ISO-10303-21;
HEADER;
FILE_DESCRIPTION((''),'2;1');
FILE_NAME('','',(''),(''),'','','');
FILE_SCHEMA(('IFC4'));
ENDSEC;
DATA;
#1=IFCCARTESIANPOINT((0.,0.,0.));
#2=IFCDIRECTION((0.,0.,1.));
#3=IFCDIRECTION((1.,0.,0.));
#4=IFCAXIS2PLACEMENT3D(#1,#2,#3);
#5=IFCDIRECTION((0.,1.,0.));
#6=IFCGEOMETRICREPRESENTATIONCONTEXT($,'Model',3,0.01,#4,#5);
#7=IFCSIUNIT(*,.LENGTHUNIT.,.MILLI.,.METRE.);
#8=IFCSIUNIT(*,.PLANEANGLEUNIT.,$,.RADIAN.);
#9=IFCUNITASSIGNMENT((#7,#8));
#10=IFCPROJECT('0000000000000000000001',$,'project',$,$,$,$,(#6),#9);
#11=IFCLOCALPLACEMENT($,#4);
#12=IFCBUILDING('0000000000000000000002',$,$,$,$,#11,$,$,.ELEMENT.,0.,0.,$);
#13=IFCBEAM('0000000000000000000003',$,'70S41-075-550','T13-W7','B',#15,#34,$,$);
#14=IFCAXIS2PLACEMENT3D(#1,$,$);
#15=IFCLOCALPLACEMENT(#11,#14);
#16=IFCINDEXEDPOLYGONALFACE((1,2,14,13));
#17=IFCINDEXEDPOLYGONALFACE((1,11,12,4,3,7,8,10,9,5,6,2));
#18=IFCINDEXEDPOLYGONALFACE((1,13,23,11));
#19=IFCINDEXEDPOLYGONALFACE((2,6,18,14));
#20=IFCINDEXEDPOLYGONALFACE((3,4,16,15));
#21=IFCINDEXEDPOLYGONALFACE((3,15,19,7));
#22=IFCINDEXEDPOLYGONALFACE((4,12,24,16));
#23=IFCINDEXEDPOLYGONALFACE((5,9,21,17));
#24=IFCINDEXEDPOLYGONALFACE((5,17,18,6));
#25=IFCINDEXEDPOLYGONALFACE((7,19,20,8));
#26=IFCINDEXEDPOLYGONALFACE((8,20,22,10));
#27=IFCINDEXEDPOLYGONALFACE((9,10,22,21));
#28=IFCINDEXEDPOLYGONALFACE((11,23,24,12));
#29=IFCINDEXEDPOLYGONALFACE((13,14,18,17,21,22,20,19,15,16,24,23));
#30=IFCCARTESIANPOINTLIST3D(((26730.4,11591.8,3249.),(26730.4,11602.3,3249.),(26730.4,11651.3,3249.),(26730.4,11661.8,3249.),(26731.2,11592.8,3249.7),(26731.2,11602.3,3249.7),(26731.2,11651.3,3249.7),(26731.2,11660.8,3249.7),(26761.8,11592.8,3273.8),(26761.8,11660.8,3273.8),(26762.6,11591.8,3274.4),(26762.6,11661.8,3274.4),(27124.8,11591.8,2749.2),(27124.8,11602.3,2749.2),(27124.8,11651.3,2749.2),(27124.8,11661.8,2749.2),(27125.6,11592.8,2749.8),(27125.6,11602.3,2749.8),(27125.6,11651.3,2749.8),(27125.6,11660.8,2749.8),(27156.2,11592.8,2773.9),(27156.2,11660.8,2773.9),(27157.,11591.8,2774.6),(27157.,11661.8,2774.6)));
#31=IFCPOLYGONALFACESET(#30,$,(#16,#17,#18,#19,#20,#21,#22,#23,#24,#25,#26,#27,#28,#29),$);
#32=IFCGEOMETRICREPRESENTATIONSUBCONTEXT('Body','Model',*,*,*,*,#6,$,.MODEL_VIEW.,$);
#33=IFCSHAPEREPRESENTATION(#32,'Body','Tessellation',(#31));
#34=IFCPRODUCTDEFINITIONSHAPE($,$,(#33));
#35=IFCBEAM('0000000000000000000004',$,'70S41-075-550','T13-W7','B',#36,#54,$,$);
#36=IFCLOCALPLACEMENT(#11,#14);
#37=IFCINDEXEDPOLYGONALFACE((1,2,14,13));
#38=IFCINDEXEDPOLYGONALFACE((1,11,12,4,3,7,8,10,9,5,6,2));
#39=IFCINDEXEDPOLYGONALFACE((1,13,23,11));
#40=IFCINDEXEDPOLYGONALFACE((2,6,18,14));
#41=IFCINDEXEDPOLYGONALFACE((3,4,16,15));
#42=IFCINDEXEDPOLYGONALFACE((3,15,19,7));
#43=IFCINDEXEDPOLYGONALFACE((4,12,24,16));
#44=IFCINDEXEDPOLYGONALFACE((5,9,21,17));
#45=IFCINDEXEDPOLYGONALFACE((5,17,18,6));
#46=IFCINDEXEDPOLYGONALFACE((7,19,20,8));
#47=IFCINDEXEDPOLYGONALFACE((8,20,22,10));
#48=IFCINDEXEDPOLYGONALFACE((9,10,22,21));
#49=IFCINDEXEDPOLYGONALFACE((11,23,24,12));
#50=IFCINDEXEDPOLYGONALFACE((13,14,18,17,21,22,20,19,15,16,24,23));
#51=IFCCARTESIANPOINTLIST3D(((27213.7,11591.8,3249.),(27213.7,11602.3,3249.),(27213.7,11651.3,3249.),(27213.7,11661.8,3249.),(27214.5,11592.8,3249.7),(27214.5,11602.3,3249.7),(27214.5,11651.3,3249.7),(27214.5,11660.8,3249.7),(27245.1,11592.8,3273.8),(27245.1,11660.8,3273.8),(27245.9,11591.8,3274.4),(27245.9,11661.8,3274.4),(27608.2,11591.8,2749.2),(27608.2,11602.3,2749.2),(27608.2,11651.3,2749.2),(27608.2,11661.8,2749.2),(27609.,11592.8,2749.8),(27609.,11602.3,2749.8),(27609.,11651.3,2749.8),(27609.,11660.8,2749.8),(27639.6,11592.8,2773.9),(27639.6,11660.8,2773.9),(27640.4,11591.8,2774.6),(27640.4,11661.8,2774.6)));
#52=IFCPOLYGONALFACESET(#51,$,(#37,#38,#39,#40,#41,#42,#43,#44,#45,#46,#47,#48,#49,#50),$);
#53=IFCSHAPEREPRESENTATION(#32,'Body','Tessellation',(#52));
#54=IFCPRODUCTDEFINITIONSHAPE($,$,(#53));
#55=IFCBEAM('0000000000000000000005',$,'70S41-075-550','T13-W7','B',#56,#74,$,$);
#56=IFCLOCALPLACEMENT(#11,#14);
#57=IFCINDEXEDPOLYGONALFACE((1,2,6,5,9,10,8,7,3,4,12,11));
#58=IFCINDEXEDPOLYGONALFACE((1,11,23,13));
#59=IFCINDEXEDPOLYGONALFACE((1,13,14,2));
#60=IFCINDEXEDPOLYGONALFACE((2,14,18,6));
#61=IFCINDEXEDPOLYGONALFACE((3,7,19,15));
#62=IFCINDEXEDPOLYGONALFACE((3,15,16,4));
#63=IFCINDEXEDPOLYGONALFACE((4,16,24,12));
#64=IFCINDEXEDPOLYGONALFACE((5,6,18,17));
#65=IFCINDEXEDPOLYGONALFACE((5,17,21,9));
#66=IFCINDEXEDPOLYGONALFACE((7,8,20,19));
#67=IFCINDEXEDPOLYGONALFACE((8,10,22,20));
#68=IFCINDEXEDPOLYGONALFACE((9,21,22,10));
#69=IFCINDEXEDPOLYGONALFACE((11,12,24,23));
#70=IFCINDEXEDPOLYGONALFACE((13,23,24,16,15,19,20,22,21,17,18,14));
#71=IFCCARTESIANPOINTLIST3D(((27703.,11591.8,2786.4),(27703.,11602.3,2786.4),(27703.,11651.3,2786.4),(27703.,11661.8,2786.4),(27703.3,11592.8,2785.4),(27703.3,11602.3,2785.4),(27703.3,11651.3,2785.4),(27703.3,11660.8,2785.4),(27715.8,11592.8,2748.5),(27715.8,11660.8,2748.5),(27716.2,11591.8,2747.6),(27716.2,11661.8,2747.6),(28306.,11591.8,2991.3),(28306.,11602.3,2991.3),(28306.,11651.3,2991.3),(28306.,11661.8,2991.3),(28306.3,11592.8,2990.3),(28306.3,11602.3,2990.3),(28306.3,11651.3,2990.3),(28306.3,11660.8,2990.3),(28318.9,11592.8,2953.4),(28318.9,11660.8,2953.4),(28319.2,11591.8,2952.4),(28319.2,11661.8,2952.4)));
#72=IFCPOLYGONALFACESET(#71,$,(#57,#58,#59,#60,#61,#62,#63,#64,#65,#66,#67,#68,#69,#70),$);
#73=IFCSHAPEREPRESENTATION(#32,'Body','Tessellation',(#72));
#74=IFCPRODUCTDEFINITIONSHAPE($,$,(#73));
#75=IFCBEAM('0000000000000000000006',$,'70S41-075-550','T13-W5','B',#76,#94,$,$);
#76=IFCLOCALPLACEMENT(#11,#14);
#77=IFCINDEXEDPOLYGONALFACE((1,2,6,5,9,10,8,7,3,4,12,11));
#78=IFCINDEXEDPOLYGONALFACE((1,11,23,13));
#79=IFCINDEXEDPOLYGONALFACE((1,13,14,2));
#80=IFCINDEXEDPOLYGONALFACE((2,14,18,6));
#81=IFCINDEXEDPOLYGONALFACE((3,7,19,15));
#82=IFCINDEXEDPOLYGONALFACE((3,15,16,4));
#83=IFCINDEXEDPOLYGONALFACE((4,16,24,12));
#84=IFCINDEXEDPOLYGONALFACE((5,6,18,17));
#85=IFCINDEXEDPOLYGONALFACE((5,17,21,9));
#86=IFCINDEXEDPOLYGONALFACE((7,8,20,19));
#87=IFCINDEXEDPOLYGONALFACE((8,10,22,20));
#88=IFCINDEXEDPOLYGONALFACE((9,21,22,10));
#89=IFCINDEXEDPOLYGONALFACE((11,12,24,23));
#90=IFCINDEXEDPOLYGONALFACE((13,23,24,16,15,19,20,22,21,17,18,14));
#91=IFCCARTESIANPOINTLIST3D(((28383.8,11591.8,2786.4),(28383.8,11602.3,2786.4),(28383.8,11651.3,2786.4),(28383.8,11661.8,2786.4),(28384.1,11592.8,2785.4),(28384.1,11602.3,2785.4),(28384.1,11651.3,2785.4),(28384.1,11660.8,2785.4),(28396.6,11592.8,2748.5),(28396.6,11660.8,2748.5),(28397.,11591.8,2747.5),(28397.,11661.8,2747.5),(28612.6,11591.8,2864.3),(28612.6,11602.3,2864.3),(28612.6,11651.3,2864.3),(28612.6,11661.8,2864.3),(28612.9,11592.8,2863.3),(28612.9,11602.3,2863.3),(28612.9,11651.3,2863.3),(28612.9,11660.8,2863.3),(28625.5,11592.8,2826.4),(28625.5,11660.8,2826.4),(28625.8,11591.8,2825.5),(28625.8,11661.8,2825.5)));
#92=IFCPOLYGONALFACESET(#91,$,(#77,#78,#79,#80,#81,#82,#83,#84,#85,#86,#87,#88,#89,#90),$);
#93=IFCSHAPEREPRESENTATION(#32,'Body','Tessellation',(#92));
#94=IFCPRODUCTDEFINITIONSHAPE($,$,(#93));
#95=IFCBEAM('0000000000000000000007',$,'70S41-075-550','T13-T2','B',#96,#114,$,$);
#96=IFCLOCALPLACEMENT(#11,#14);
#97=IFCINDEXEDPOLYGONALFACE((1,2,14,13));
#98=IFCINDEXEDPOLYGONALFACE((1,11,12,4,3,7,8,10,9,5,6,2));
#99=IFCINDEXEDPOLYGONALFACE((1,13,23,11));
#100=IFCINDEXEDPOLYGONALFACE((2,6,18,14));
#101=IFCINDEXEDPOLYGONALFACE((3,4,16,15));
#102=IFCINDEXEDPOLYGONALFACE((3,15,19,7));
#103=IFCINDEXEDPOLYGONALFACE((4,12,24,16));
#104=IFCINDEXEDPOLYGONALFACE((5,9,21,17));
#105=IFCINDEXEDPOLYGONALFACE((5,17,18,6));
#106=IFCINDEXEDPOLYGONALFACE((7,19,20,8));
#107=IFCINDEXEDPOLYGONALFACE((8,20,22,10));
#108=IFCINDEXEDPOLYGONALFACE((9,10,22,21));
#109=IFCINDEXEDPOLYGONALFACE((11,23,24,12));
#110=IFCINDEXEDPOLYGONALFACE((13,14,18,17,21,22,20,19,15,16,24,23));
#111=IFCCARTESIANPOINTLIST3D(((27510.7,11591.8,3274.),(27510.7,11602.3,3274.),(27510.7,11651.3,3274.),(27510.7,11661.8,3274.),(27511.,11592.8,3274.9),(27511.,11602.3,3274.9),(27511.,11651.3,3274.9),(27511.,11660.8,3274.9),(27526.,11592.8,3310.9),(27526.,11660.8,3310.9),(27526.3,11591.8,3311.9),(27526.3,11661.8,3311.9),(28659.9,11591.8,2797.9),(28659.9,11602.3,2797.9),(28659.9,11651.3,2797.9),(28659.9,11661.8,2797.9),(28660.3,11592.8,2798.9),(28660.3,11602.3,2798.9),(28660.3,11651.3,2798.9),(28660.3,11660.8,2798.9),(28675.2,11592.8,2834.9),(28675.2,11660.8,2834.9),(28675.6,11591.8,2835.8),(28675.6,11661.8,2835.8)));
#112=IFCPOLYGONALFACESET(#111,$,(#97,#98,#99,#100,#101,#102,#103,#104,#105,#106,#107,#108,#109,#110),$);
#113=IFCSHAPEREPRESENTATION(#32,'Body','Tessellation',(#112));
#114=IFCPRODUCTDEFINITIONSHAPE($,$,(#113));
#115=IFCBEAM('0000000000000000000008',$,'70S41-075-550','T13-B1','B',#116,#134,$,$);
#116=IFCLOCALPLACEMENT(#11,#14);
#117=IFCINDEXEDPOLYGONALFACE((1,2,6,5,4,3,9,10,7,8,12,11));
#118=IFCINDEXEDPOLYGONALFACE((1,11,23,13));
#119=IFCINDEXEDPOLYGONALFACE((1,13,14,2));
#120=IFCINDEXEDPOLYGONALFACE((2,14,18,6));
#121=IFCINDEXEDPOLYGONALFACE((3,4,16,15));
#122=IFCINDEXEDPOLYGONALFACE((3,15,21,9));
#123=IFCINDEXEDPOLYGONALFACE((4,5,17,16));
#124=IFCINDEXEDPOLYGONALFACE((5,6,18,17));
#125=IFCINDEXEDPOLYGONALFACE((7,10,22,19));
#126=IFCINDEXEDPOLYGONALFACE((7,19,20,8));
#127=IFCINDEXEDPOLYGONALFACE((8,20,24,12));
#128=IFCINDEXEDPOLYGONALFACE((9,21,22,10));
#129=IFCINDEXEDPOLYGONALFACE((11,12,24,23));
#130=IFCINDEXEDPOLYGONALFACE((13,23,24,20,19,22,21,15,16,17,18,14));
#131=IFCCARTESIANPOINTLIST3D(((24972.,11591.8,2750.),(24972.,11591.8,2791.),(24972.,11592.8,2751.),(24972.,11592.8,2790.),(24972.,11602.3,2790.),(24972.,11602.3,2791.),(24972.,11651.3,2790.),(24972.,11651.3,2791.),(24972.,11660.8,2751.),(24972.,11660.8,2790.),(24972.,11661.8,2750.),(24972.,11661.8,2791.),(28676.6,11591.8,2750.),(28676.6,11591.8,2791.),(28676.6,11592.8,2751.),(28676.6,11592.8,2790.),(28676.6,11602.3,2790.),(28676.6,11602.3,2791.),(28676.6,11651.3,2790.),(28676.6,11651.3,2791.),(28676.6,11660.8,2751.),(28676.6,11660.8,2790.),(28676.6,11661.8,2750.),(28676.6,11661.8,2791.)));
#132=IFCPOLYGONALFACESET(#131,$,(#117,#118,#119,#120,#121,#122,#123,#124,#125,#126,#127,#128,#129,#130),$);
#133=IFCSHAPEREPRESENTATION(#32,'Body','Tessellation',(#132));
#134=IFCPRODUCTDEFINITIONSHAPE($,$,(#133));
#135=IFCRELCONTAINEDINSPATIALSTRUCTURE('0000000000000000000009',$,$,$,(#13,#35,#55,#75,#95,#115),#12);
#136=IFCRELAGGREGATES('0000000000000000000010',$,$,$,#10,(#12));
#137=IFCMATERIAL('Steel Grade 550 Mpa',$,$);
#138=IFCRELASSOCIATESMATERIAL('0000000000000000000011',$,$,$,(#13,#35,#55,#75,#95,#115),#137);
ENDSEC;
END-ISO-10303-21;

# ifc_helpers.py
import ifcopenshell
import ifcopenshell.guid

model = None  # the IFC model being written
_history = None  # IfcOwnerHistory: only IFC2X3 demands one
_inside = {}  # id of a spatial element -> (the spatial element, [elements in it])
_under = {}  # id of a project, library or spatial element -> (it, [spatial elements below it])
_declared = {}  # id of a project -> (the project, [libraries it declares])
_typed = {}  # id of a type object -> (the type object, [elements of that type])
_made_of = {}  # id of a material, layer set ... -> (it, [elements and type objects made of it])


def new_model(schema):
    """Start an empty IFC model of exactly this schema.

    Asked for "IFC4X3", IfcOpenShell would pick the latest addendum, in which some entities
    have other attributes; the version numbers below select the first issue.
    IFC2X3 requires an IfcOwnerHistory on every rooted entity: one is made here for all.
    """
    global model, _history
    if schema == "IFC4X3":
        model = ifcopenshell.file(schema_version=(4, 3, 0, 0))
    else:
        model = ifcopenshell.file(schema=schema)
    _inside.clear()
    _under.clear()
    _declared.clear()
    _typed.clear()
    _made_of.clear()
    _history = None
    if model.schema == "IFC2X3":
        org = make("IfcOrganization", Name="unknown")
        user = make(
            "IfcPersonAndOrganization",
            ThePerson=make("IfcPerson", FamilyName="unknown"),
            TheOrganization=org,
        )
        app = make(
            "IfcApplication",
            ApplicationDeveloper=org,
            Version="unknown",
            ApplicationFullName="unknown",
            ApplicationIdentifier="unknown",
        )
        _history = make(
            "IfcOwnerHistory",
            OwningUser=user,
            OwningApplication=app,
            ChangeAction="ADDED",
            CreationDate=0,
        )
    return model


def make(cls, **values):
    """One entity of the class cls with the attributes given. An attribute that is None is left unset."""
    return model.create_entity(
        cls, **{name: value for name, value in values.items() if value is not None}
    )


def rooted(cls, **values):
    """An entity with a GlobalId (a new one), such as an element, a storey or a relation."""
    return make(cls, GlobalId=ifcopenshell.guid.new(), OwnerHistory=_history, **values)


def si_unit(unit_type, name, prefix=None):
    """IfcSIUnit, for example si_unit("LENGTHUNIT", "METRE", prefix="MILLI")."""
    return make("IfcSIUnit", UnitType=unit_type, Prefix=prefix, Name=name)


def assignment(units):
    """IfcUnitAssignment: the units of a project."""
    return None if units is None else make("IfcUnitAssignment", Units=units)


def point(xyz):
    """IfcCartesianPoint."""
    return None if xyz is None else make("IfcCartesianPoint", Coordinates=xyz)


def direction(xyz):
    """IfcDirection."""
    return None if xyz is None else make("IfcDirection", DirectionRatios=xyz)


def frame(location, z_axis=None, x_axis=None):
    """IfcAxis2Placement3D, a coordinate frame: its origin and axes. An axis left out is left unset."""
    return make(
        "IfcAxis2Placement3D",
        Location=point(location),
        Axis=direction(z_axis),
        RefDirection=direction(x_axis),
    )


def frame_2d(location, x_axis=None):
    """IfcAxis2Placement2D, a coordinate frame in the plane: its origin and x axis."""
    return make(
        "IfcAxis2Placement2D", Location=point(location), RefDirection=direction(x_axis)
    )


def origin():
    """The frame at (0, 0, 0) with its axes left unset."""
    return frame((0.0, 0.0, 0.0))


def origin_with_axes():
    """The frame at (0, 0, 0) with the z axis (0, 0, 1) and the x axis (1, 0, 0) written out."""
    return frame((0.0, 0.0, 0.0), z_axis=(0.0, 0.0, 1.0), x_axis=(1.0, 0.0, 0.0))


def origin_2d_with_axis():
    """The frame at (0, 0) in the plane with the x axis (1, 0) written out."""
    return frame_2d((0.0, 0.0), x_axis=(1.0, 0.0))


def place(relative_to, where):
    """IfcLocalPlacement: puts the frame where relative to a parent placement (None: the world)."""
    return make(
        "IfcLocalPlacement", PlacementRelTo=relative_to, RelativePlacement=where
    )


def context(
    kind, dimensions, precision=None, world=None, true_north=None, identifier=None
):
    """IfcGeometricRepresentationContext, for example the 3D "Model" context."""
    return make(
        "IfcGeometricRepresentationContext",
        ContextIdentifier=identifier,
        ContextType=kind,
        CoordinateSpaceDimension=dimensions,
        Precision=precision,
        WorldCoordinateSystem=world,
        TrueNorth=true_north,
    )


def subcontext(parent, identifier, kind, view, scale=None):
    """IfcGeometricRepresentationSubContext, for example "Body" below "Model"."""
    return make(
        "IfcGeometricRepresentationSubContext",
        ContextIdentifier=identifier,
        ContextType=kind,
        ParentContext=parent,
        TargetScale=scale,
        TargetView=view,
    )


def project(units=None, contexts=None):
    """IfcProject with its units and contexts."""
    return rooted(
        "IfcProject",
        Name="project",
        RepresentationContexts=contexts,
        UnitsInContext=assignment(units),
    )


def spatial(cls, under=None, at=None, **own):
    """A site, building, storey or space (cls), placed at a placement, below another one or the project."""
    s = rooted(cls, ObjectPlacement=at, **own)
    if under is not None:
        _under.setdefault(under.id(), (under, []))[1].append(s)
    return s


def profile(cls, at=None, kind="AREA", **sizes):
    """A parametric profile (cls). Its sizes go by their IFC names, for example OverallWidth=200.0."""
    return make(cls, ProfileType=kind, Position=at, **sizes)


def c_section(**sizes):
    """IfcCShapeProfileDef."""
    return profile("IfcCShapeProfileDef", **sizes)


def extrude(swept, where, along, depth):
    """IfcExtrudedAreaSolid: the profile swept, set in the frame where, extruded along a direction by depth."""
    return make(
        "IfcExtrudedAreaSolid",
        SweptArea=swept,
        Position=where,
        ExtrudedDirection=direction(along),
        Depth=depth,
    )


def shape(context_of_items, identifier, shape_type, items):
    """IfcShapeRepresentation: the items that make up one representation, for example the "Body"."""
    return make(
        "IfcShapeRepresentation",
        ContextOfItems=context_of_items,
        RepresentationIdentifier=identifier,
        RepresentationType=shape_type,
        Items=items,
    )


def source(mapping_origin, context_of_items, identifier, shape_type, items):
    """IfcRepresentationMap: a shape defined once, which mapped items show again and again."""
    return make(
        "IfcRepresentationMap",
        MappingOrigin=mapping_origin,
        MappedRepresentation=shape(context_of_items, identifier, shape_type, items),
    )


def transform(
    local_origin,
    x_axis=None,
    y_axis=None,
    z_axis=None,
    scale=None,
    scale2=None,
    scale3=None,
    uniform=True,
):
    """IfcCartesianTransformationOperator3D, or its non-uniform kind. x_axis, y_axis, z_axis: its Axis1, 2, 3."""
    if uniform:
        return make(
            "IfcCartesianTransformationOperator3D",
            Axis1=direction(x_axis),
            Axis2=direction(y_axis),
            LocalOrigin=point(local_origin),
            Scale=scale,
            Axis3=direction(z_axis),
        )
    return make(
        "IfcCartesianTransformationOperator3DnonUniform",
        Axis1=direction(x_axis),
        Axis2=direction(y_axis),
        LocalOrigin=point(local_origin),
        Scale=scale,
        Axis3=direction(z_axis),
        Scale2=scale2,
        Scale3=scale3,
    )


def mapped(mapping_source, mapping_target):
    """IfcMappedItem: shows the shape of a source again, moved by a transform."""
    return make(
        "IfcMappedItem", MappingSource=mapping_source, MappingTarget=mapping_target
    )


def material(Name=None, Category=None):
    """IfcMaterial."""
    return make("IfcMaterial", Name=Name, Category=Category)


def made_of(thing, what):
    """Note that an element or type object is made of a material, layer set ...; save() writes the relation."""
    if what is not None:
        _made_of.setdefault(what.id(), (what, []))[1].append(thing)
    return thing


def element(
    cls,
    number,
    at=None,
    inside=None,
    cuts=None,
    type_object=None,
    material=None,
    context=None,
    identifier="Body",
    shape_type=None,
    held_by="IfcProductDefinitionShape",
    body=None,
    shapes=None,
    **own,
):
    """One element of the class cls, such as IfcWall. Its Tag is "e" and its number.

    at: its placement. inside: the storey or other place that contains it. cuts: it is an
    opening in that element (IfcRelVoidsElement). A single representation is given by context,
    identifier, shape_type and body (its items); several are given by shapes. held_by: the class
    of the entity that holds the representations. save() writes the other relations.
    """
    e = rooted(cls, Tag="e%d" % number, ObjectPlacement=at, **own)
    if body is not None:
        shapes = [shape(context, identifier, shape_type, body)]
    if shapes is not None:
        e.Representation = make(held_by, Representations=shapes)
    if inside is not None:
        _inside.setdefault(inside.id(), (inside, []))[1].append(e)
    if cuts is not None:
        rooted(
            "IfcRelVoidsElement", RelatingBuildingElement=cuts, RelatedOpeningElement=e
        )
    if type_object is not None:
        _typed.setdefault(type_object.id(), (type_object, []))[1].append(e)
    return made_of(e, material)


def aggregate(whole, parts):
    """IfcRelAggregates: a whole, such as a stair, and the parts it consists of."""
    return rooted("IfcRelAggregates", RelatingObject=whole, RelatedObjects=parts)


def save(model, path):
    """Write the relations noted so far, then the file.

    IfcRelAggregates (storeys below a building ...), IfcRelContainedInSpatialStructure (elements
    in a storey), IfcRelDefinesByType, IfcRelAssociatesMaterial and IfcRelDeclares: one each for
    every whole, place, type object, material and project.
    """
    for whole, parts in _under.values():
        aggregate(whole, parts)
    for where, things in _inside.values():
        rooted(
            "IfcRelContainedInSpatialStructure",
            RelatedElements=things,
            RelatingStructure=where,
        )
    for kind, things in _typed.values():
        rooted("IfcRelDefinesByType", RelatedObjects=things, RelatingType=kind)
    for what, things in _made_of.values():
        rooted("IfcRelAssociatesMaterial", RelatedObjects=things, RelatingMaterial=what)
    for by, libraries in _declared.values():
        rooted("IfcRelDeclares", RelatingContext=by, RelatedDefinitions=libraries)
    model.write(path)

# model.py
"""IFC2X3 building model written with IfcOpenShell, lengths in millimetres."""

from ifc_helpers import new_model, si_unit, direction, frame, origin, origin_with_axes, origin_2d_with_axis, place, context, subcontext, project, spatial, c_section, extrude, source, transform, mapped, material, element, save


model = new_model("IFC2X3")

# Units and contexts
model_context = context("Model", 3, precision=0.01, world=origin_with_axes(), true_north=direction((0.0, 1.0, 0.0)))
body_context = subcontext(model_context, "Body", "Model", "MODEL_VIEW")
ifc_project = project(units=[si_unit("LENGTHUNIT", "METRE", prefix="MILLI"), si_unit("PLANEANGLEUNIT", "RADIAN")], contexts=[model_context])

# Building
building_placement = place(None, origin_with_axes())
building = spatial("IfcBuilding", under=ifc_project, at=building_placement, CompositionType="ELEMENT", ElevationOfRefHeight=0.0, ElevationOfTerrain=0.0)

# Shared definitions
ifc_material = material(Name="Steel Grade 550 Mpa")

# Beams
shared_shape_1 = source(origin(), body_context, "Body", "SweptSolid", [
    extrude(c_section(Depth=70.0, Width=41.0, WallThickness=1.0, Girth=10.5, at=origin_2d_with_axis()), origin_with_axes(), (0.0, 0.0, 1.0), 636.8),
])
beam_1_placement = place(None, frame((26746.5, 11626.8, 3261.7), z_axis=(0.61949, 0.0, -0.785005), x_axis=(-0.785005, 0.0, -0.61949)))
element("IfcBeam", 1, at=beam_1_placement, inside=building, material=ifc_material, Name="70S41-075-550", Description="T13-W7", ObjectType="B", context=body_context, shape_type="MappedRepresentation", body=[
    mapped(shared_shape_1, transform((0.0, 0.0, 0.0), scale=1.0)),
])
shared_shape_2 = source(origin(), body_context, "Body", "SweptSolid", [
    extrude(c_section(Depth=70.0, Width=41.0, WallThickness=1.0, Girth=10.5, at=origin_2d_with_axis()), origin_with_axes(), (0.0, 0.0, 1.0), 636.8),
])
beam_2_placement = place(None, frame((27229.8, 11626.8, 3261.7), z_axis=(0.61949, 0.0, -0.785005), x_axis=(-0.785005, 0.0, -0.61949)))
element("IfcBeam", 2, at=beam_2_placement, inside=building, material=ifc_material, Name="70S41-075-550", Description="T13-W7", ObjectType="B", context=body_context, shape_type="MappedRepresentation", body=[
    mapped(shared_shape_2, transform((0.0, 0.0, 0.0), scale=1.0)),
])
shared_shape_3 = source(origin(), body_context, "Body", "SweptSolid", [
    extrude(c_section(Depth=70.0, Width=41.0, WallThickness=1.0, Girth=10.5, at=origin_2d_with_axis()), origin_with_axes(), (0.0, 0.0, 1.0), 636.9),
])
beam_3_placement = place(None, frame((28312.6, 11626.8, 2971.9), z_axis=(-0.946838, 0.0, -0.32171), x_axis=(-0.32171, 0.0, 0.946838)))
element("IfcBeam", 3, at=beam_3_placement, inside=building, material=ifc_material, Name="70S41-075-550", Description="T13-W7", ObjectType="B", context=body_context, shape_type="MappedRepresentation", body=[
    mapped(shared_shape_3, transform((0.0, 0.0, 0.0), scale=1.0)),
])
shared_shape_4 = source(origin(), body_context, "Body", "SweptSolid", [
    extrude(c_section(Depth=70.0, Width=41.0, WallThickness=1.0, Girth=10.5, at=origin_2d_with_axis()), origin_with_axes(), (0.0, 0.0, 1.0), 241.7),
])
beam_4_placement = place(None, frame((28619.2, 11626.8, 2844.9), z_axis=(-0.946646, 0.0, -0.322276), x_axis=(-0.322276, 0.0, 0.946646)))
element("IfcBeam", 4, at=beam_4_placement, inside=building, material=ifc_material, Name="70S41-075-550", Description="T13-W5", ObjectType="B", context=body_context, shape_type="MappedRepresentation", body=[
    mapped(shared_shape_4, transform((0.0, 0.0, 0.0), scale=1.0)),
])
shared_shape_5 = source(origin(), body_context, "Body", "SweptSolid", [
    extrude(c_section(Depth=70.0, Width=41.0, WallThickness=1.0, Girth=10.5, at=origin_2d_with_axis()), origin_with_axes(), (0.0, 0.0, 1.0), 1244.0),
])
beam_5_placement = place(None, frame((27518.5, 11626.8, 3292.9), z_axis=(0.92388, 0.0, -0.382683), x_axis=(-0.382683, 0.0, -0.92388)))
element("IfcBeam", 5, at=beam_5_placement, inside=building, material=ifc_material, Name="70S41-075-550", Description="T13-T2", ObjectType="B", context=body_context, shape_type="MappedRepresentation", body=[
    mapped(shared_shape_5, transform((0.0, 0.0, 0.0), scale=1.0)),
])
shared_shape_6 = source(origin(), body_context, "Body", "SweptSolid", [
    extrude(c_section(Depth=70.0, Width=41.0, WallThickness=1.0, Girth=10.5, at=origin_2d_with_axis()), origin_with_axes(), (0.0, 0.0, 1.0), 3704.6),
])
beam_6_placement = place(None, frame((28676.6, 11626.8, 2770.5), z_axis=(-1.0, 0.0, 0.0), x_axis=(0.0, 0.0, 1.0)))
element("IfcBeam", 6, at=beam_6_placement, inside=building, material=ifc_material, Name="70S41-075-550", Description="T13-B1", ObjectType="B", context=body_context, shape_type="MappedRepresentation", body=[
    mapped(shared_shape_6, transform((0.0, 0.0, 0.0), scale=1.0)),
])

save(model, "model.ifc")
